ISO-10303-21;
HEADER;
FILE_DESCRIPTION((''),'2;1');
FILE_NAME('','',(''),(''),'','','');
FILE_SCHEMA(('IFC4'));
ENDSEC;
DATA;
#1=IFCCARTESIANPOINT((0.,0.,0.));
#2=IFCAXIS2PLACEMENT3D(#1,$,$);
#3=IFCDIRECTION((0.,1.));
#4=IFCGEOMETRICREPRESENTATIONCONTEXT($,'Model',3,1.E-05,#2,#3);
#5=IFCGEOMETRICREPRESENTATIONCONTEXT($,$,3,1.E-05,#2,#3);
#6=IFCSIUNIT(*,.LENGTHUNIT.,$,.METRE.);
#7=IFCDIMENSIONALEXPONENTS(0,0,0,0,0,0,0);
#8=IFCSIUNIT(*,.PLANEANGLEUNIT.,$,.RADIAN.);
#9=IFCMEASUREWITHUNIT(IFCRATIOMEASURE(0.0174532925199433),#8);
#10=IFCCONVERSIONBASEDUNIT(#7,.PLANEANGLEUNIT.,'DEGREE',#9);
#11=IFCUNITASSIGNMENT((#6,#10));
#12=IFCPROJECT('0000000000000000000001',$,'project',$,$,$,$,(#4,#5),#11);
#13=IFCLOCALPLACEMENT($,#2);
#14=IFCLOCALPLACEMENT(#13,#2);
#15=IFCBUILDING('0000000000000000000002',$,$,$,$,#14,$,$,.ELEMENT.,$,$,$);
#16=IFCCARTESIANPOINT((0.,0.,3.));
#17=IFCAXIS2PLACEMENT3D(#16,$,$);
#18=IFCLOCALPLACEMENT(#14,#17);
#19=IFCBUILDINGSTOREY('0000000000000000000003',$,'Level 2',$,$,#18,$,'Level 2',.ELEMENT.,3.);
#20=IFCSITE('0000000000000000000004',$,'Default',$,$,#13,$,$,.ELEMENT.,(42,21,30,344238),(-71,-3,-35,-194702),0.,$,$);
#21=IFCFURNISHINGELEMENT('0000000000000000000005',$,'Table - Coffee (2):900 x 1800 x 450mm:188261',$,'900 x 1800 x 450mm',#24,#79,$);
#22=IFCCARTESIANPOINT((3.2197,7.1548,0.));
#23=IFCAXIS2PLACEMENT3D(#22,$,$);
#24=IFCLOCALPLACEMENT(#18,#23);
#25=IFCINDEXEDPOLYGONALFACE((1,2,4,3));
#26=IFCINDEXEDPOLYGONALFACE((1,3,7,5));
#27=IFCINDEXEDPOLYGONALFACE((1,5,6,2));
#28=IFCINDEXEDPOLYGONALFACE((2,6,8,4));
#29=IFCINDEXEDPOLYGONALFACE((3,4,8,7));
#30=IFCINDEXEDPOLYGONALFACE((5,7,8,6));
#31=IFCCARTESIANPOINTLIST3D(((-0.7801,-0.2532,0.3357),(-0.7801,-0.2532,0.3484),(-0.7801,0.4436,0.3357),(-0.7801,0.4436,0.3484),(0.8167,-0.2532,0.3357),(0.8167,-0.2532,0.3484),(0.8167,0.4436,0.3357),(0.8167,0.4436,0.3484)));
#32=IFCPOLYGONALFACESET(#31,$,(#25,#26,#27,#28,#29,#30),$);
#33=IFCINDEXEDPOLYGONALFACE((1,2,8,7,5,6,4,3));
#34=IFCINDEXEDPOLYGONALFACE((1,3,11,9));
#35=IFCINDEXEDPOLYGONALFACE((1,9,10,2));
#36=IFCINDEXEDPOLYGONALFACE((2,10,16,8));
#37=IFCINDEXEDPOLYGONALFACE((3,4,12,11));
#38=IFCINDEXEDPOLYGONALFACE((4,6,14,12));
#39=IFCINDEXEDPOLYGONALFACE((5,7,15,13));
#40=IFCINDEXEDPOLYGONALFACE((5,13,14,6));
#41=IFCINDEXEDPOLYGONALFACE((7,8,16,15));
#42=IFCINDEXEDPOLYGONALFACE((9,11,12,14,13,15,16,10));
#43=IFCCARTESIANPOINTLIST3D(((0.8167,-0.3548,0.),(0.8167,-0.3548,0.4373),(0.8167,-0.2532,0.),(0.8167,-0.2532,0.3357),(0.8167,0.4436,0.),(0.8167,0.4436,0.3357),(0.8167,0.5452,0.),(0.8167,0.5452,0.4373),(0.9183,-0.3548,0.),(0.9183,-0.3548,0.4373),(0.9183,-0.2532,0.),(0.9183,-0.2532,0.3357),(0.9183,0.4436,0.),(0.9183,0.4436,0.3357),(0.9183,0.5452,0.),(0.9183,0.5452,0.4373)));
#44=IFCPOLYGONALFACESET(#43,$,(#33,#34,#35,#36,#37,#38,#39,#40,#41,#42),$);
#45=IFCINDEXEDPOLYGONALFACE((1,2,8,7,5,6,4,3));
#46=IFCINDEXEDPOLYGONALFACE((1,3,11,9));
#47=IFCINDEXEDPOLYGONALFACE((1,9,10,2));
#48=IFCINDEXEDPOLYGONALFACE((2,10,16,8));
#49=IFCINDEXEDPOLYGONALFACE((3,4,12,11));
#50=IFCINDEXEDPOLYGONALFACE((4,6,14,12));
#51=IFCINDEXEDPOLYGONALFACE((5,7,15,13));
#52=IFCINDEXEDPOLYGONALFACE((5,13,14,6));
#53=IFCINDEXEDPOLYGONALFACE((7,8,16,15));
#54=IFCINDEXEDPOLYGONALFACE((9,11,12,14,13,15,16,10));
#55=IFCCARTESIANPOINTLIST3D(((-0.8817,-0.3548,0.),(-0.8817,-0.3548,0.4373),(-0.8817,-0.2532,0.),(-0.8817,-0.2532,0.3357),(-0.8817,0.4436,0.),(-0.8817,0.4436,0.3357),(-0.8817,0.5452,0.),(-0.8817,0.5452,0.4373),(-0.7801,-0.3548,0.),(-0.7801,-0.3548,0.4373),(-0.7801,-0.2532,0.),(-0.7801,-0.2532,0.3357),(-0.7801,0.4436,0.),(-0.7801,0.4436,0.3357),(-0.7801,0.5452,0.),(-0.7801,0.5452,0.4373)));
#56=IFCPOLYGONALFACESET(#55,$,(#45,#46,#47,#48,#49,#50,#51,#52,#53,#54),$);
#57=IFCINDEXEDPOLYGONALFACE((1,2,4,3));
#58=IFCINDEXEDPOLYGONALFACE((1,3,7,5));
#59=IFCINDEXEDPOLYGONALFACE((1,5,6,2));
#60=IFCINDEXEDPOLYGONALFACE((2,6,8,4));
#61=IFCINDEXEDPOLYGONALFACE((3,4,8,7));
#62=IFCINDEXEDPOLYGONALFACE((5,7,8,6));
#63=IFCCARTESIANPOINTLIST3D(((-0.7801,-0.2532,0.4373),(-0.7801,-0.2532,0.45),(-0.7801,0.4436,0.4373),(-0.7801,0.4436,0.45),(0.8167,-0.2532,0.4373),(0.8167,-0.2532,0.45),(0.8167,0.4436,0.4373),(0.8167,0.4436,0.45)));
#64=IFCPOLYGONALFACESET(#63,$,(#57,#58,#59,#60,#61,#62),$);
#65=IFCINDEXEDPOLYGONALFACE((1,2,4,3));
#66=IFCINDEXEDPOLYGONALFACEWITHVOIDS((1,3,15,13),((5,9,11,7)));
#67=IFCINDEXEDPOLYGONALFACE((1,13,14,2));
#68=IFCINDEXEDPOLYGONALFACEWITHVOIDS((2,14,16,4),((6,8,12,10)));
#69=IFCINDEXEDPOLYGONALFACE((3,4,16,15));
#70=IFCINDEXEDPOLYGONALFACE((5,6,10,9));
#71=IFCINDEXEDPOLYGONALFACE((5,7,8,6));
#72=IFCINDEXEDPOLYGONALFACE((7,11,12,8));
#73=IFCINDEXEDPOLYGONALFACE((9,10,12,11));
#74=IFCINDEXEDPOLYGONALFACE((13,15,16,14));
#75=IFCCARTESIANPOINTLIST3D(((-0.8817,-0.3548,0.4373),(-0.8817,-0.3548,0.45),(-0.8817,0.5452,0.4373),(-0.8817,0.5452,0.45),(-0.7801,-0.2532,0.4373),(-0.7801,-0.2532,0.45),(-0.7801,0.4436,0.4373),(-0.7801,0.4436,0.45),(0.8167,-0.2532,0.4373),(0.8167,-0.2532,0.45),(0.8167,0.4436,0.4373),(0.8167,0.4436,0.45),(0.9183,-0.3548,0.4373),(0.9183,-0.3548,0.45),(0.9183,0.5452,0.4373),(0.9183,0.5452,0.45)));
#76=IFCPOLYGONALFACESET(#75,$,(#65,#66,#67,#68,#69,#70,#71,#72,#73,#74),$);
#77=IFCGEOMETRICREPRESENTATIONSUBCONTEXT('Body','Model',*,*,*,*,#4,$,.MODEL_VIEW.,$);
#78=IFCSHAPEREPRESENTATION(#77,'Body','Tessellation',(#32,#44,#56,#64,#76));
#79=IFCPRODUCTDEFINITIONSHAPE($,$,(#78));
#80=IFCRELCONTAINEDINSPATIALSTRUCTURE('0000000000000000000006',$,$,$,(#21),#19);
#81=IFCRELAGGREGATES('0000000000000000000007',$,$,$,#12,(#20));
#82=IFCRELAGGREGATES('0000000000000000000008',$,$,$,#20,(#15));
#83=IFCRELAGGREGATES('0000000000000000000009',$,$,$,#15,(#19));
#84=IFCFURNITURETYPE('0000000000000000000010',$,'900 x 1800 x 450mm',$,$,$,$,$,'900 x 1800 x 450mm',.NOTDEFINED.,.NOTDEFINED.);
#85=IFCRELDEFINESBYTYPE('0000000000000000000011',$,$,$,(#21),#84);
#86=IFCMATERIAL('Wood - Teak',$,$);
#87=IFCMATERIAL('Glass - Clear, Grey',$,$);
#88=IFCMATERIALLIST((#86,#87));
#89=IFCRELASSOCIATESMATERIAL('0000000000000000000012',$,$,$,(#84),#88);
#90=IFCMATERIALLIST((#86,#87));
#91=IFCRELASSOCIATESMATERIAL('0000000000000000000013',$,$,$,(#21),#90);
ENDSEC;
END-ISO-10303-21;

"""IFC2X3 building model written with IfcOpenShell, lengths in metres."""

from ifc_helpers import new_model, entity, si_unit, converted_unit, direction, frame, origin, origin_2d_with_axis, place, context, subcontext, project, spatial, polyline, rectangle, outline, extrude, source, transform, mapped, material, material_list, type_object, type_shapes, element, save


model = new_model("IFC2X3")

# Units and contexts
model_context = context("Model", 3, precision=1e-05, world=origin(), true_north=direction((0.0, 1.0)))
context_of_model = context(None, 3, precision=1e-05, world=origin(), true_north=direction((0.0, 1.0)))
body_context = subcontext(model_context, "Body", "Model", "MODEL_VIEW")
ifc_project = project(units=[si_unit("LENGTHUNIT", "METRE"), converted_unit("PLANEANGLEUNIT", "DEGREE", entity("IfcRatioMeasure", 0.0174532925199433), si_unit("PLANEANGLEUNIT", "RADIAN"), dimensions=[0, 0, 0, 0, 0, 0, 0])], contexts=[model_context, context_of_model])

# Site, building, storey
site_placement = place(None, origin())
site = spatial("IfcSite", under=ifc_project, at=site_placement, Name="Default", CompositionType="ELEMENT", RefLatitude=(42, 21, 30, 344238), RefLongitude=(-71, -3, -35, -194702), RefElevation=0.0)
building_placement = place(site_placement, origin())
building = spatial("IfcBuilding", under=site, at=building_placement, CompositionType="ELEMENT")
storey_placement = place(building_placement, frame((0.0, 0.0, 3.0)))
storey = spatial("IfcBuildingStorey", under=building, at=storey_placement, Name="Level 2", LongName="Level 2", CompositionType="ELEMENT", Elevation=3.0)

# Furnishing element
ifc_material_1 = material(Name="Wood - Teak")
ifc_material_2 = material(Name="Glass - Clear, Grey")
ifc_material_list_1 = material_list([ifc_material_1, ifc_material_2])
ifc_material_list_2 = material_list([ifc_material_1, ifc_material_2])
furniture_type_1 = type_object("IfcFurnitureType", Name="900 x 1800 x 450mm", ElementType="900 x 1800 x 450mm", AssemblyPlace="NOTDEFINED", material=ifc_material_list_2)
shared_shape_1 = source(origin(), body_context, "Body", "SweptSolid", [
    extrude(rectangle(XDim=1.5968, YDim=0.6968, at=origin_2d_with_axis()), frame((0.0183, 0.0952, 0.3357), z_axis=(0.0, 0.0, 1.0), x_axis=(-1.0, 0.0, 0.0)), (0.0, 0.0, 1.0), 0.0127),
    extrude(outline(polyline([(-0.1932, -0.45), (0.244, -0.45), (0.244, 0.45), (-0.1932, 0.45), (-0.1932, 0.3484), (0.1425, 0.3484), (0.1425, -0.3484), (-0.1932, -0.3484), (-0.1932, -0.45)])), frame((0.8167, 0.0952, 0.1932), z_axis=(1.0, 0.0, 0.0), x_axis=(0.0, 0.0, 1.0)), (0.0, 0.0, 1.0), 0.1016),
    extrude(outline(polyline([(-0.45, -0.2441), (0.45, -0.2441), (0.45, 0.1933), (0.3484, 0.1933), (0.3484, -0.1424), (-0.3484, -0.1424), (-0.3484, 0.1933), (-0.45, 0.1933), (-0.45, -0.2441)])), frame((-0.8817, 0.0952, 0.1933), z_axis=(1.0, 0.0, 0.0), x_axis=(0.0, -1.0, 0.0)), (0.0, 0.0, 1.0), 0.1016),
    extrude(rectangle(XDim=1.5968, YDim=0.6968, at=origin_2d_with_axis()), frame((0.0183, 0.0952, 0.4373), z_axis=(0.0, 0.0, 1.0), x_axis=(-1.0, 0.0, 0.0)), (0.0, 0.0, 1.0), 0.0127),
    extrude(outline(polyline([(-0.9, -0.45), (0.9, -0.45), (0.9, 0.45), (-0.9, 0.45), (-0.9, -0.45)]), holes=[polyline([(-0.7984, -0.3484), (-0.7984, 0.3484), (0.7984, 0.3484), (0.7984, -0.3484), (-0.7984, -0.3484)])]), frame((0.0183, 0.0952, 0.4373), z_axis=(0.0, 0.0, 1.0), x_axis=(-1.0, 0.0, 0.0)), (0.0, 0.0, 1.0), 0.0127),
])
type_shapes(furniture_type_1, [shared_shape_1])
furnishing_1_placement = place(storey_placement, frame((3.2197, 7.1548, 0.0)))
element("IfcFurnishingElement", 1, at=furnishing_1_placement, inside=storey, type_object=furniture_type_1, material=ifc_material_list_1, Name="Table - Coffee (2):900 x 1800 x 450mm:188261", ObjectType="900 x 1800 x 450mm", context=body_context, shape_type="MappedRepresentation", body=[
    mapped(shared_shape_1, transform((0.0, 0.0, 0.0), scale=1.0)),
])

save(model, "model.ifc")
